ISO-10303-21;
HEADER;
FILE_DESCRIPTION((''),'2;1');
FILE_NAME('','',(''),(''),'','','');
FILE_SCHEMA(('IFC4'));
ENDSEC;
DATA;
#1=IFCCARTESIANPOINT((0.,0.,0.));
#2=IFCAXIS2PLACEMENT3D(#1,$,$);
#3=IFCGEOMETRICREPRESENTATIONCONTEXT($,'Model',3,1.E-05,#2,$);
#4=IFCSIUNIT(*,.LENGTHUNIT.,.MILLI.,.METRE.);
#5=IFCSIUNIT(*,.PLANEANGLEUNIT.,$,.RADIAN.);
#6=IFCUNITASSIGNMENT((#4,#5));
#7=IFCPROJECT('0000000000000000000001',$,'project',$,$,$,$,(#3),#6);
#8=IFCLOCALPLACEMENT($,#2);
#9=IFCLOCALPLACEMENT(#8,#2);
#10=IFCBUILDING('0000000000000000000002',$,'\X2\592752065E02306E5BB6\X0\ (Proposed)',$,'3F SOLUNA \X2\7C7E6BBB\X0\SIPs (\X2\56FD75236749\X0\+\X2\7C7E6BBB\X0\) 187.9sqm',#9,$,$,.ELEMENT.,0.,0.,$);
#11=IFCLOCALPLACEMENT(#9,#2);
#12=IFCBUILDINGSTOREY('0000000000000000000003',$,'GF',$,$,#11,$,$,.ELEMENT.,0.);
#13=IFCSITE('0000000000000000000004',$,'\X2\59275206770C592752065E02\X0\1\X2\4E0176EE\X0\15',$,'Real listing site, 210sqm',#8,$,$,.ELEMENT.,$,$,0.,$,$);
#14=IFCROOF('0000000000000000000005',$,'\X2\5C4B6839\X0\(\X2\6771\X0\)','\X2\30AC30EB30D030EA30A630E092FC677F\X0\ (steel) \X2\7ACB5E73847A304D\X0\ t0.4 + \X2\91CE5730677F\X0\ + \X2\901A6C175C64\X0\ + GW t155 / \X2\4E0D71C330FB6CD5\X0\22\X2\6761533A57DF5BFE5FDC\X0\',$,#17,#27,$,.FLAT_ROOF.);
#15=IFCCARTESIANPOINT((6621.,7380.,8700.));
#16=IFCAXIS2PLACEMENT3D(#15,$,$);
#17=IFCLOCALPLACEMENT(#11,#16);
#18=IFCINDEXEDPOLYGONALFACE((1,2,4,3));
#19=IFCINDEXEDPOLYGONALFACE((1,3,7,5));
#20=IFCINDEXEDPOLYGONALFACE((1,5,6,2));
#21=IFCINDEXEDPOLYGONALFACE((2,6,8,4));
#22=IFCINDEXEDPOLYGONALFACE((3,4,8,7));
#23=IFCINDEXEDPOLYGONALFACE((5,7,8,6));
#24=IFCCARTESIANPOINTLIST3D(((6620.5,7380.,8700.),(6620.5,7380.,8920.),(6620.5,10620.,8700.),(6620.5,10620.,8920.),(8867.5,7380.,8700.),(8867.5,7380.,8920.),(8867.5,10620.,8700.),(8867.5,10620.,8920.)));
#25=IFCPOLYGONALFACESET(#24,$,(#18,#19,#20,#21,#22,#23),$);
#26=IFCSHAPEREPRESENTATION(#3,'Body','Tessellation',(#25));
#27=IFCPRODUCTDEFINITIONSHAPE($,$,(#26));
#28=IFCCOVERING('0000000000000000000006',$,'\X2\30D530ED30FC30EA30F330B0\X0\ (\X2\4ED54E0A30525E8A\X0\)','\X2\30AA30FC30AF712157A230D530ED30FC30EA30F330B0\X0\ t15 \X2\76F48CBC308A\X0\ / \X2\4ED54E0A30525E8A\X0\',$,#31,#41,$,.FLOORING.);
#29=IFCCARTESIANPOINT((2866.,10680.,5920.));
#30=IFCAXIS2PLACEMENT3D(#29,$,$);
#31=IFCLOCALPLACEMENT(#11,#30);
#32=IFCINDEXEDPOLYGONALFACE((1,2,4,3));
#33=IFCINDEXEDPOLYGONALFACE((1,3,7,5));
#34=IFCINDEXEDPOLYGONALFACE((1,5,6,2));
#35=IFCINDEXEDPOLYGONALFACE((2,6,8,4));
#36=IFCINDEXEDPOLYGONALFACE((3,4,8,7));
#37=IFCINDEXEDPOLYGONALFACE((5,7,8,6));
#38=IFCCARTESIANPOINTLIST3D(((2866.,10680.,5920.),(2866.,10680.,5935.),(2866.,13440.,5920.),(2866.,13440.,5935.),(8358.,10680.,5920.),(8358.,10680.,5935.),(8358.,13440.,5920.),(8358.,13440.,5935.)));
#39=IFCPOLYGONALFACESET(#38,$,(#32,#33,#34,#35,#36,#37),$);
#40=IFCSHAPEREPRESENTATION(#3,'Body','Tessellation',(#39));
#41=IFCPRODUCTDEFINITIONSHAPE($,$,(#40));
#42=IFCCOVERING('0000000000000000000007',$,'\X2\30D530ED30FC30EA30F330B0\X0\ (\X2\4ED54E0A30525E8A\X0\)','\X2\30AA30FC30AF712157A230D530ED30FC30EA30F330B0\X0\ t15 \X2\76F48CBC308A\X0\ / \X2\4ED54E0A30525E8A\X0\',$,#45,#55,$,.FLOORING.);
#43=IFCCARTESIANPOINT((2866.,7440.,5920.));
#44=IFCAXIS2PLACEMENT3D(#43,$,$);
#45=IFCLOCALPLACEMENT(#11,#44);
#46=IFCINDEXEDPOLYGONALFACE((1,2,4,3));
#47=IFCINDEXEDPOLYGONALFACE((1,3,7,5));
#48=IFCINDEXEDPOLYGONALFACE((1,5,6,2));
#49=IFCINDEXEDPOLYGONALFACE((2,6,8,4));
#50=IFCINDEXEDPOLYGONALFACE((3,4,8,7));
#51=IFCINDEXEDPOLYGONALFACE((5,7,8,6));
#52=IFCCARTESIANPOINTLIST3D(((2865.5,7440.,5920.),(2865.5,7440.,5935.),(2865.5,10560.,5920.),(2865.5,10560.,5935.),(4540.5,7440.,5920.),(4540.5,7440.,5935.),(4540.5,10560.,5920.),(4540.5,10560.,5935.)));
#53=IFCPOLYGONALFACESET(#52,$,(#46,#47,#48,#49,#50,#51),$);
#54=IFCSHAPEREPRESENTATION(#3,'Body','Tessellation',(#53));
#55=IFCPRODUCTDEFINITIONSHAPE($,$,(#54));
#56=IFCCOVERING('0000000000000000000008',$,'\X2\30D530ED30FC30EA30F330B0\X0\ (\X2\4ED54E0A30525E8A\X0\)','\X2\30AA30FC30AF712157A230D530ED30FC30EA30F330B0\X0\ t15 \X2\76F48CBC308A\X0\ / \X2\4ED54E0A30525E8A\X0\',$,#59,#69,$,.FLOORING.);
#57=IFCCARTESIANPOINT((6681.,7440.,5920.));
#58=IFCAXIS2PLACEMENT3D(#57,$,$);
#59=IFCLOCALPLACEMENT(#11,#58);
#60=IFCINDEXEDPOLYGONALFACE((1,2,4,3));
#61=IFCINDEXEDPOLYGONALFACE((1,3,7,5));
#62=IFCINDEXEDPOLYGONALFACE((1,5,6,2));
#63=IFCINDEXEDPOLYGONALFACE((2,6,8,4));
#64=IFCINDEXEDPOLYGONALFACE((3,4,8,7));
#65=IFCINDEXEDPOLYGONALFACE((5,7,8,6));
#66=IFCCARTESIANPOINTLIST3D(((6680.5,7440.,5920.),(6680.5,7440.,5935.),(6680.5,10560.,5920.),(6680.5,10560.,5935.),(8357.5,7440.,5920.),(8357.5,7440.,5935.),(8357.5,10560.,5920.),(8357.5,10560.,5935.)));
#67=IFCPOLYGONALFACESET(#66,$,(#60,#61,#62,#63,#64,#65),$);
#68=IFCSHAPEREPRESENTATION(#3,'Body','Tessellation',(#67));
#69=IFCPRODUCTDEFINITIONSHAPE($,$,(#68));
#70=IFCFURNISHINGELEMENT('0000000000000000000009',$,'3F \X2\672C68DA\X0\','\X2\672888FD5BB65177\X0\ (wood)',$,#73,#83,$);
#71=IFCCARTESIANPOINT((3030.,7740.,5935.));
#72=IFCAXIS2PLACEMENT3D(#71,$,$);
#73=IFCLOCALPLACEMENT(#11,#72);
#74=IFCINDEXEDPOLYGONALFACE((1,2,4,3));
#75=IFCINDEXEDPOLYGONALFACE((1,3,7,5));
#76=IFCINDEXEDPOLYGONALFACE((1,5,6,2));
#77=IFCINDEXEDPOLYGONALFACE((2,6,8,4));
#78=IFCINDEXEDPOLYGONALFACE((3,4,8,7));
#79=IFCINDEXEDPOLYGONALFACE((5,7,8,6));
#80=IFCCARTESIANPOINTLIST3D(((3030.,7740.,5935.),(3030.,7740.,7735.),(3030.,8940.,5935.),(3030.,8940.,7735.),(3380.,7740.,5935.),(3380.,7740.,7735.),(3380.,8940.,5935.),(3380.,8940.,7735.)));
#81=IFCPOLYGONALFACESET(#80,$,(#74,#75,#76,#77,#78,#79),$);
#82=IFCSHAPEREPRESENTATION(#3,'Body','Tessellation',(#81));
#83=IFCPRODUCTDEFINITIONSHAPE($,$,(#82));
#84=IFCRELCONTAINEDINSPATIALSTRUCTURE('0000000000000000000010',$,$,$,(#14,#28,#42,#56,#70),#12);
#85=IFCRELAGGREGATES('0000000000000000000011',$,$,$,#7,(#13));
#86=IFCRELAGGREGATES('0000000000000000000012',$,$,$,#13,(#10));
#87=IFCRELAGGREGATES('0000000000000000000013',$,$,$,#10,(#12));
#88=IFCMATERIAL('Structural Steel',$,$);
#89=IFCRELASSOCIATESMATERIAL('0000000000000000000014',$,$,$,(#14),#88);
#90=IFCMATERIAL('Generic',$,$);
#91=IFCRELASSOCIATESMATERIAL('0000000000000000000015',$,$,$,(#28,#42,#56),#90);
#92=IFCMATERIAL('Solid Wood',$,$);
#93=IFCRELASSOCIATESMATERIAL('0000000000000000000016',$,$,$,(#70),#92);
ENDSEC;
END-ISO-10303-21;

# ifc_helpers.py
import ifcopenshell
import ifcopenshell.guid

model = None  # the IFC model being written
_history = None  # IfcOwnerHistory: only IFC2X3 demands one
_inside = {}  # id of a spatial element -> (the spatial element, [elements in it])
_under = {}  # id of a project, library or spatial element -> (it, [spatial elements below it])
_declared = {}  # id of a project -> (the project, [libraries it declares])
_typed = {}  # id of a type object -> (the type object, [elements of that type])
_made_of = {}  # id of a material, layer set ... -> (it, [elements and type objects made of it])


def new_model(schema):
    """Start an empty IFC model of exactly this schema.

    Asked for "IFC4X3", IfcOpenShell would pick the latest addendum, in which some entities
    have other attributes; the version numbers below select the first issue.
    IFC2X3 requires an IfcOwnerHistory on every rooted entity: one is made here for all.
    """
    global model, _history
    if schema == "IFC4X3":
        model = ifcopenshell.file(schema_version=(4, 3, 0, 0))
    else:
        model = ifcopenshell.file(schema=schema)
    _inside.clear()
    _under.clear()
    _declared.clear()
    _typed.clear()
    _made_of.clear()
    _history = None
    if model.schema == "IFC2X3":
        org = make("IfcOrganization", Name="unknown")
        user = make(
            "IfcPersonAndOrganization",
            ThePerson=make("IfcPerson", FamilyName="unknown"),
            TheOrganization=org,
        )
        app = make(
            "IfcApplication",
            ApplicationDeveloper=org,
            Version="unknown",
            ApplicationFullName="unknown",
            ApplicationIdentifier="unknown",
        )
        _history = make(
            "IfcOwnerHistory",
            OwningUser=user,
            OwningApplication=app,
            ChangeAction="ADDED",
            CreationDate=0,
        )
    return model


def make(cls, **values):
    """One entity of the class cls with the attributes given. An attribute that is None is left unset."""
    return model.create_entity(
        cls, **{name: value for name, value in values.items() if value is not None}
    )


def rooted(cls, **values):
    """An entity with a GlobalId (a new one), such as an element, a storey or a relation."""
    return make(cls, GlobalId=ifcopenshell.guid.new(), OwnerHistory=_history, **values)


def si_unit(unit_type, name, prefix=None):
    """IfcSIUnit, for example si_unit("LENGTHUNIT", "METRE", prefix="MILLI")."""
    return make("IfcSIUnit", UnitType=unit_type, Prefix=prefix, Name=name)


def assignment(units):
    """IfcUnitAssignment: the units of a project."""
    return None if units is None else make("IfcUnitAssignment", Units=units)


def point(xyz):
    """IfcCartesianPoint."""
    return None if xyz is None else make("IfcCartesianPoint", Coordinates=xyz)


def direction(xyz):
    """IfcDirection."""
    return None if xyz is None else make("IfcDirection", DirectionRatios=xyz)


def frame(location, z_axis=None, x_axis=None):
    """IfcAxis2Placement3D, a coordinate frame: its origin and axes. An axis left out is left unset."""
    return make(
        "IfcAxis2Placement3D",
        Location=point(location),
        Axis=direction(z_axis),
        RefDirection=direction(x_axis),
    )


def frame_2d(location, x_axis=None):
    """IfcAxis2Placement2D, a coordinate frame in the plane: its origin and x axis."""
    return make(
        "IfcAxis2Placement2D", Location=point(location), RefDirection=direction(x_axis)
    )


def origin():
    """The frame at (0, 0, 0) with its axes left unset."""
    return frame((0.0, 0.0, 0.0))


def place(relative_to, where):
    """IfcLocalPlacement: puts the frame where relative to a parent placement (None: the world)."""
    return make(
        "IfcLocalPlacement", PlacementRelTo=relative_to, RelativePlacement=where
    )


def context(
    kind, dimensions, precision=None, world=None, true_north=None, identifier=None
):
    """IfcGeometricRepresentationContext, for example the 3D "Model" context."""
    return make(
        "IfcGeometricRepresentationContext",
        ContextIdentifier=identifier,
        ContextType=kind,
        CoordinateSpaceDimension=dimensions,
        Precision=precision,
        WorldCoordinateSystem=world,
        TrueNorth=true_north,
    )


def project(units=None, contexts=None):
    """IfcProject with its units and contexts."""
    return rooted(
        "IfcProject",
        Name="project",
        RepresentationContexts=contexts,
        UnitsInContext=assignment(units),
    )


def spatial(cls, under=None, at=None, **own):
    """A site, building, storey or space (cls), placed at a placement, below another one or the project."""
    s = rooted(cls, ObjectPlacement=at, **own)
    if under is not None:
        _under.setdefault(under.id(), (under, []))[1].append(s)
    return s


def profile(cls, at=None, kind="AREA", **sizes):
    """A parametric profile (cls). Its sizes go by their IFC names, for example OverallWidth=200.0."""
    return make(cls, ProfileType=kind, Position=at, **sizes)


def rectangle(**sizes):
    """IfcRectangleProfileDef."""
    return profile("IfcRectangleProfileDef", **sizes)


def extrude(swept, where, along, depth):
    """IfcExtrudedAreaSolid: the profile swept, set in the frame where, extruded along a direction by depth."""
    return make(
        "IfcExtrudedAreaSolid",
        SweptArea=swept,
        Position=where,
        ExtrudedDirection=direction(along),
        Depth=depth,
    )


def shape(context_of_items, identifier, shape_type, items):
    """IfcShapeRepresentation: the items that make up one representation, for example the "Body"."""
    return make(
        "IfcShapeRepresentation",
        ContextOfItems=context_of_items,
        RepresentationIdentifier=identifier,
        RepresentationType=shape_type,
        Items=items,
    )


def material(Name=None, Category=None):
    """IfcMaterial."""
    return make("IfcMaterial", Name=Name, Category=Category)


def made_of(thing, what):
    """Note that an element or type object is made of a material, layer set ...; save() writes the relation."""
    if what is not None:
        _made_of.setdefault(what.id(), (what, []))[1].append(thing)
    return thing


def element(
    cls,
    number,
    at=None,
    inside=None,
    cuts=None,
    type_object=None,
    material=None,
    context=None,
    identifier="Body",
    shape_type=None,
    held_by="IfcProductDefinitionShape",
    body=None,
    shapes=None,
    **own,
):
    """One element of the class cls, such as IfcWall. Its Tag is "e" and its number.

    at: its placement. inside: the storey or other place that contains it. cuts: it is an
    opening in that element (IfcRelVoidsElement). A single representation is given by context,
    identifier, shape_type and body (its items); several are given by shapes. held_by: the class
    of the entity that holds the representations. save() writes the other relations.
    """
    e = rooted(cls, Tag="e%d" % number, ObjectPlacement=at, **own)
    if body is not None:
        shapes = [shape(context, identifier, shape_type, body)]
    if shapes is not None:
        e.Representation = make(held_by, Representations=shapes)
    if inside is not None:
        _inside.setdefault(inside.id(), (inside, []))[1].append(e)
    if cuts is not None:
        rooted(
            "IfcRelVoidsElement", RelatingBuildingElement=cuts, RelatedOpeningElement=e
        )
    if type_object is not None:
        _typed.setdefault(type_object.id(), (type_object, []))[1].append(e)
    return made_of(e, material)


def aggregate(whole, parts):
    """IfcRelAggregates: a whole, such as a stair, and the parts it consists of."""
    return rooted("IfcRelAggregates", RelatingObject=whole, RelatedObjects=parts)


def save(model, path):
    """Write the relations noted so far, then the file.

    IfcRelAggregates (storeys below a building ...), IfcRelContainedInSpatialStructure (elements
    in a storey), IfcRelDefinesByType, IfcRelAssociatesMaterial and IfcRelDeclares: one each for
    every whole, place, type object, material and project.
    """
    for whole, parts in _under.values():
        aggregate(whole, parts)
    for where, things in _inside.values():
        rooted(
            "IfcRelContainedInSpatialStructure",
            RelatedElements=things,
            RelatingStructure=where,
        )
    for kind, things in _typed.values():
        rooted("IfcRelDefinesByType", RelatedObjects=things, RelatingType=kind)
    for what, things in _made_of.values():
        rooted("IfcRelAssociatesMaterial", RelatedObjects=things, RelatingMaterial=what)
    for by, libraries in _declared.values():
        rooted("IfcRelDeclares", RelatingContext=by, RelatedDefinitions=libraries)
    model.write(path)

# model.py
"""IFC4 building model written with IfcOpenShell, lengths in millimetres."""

from ifc_helpers import new_model, si_unit, frame, frame_2d, origin, place, context, project, spatial, rectangle, extrude, material, element, save


model = new_model("IFC4")

# Units and contexts
model_context = context("Model", 3, precision=1e-05, world=origin())
ifc_project = project(units=[si_unit("LENGTHUNIT", "METRE", prefix="MILLI"), si_unit("PLANEANGLEUNIT", "RADIAN")], contexts=[model_context])

# Site, building, storey
site_placement = place(None, origin())
site = spatial("IfcSite", under=ifc_project, at=site_placement, Name="大分県大分市1丁目15", ObjectType="Real listing site, 210sqm", CompositionType="ELEMENT", RefElevation=0.0)
building_placement = place(site_placement, origin())
building = spatial("IfcBuilding", under=site, at=building_placement, Name="大分市の家 (Proposed)", ObjectType="3F SOLUNA 籾殻SIPs (国産杉+籾殻) 187.9sqm", CompositionType="ELEMENT", ElevationOfRefHeight=0.0, ElevationOfTerrain=0.0)
storey_placement = place(building_placement, origin())
storey = spatial("IfcBuildingStorey", under=building, at=storey_placement, Name="GF", CompositionType="ELEMENT", Elevation=0.0)

# Shared definitions
ifc_material_1 = material(Name="Solid Wood")

# Shared definitions
ifc_material_2 = material(Name="Generic")

# Roof
ifc_material_3 = material(Name="Structural Steel")
roof_1_placement = place(storey_placement, frame((6621.0, 7380.0, 8700.0)))
element("IfcRoof", 1, at=roof_1_placement, inside=storey, material=ifc_material_3, Name="屋根(東)", Description="ガルバリウム鋼板 (steel) 立平葺き t0.4 + 野地板 + 通気層 + GW t155 / 不燃・法22条区域対応", PredefinedType="FLAT_ROOF", context=model_context, shape_type="SweptSolid", body=[
    extrude(rectangle(XDim=2247.0, YDim=3240.0, at=frame_2d((1123.0, 1620.0))), frame((6621.0, 7380.0, 8700.0)), (0.0, 0.0, 1.0), 220.0),
])

# Coverings
covering_1_placement = place(storey_placement, frame((2866.0, 10680.0, 5920.0)))
element("IfcCovering", 2, at=covering_1_placement, inside=storey, material=ifc_material_2, Name="フローリング (仕上げ床)", Description="オーク無垢フローリング t15 直貼り / 仕上げ床", PredefinedType="FLOORING", context=model_context, shape_type="SweptSolid", body=[
    extrude(rectangle(XDim=5492.0, YDim=2760.0, at=frame_2d((2746.0, 1380.0))), frame((2866.0, 10680.0, 5920.0)), (0.0, 0.0, 1.0), 15.0),
])
covering_2_placement = place(storey_placement, frame((2866.0, 7440.0, 5920.0)))
element("IfcCovering", 3, at=covering_2_placement, inside=storey, material=ifc_material_2, Name="フローリング (仕上げ床)", Description="オーク無垢フローリング t15 直貼り / 仕上げ床", PredefinedType="FLOORING", context=model_context, shape_type="SweptSolid", body=[
    extrude(rectangle(XDim=1675.0, YDim=3120.0, at=frame_2d((837.0, 1560.0))), frame((2866.0, 7440.0, 5920.0)), (0.0, 0.0, 1.0), 15.0),
])
covering_3_placement = place(storey_placement, frame((6681.0, 7440.0, 5920.0)))
element("IfcCovering", 4, at=covering_3_placement, inside=storey, material=ifc_material_2, Name="フローリング (仕上げ床)", Description="オーク無垢フローリング t15 直貼り / 仕上げ床", PredefinedType="FLOORING", context=model_context, shape_type="SweptSolid", body=[
    extrude(rectangle(XDim=1677.0, YDim=3120.0, at=frame_2d((838.0, 1560.0))), frame((6681.0, 7440.0, 5920.0)), (0.0, 0.0, 1.0), 15.0),
])

# Furnishing element
furnishing_placement = place(storey_placement, frame((3030.0, 7740.0, 5935.0)))
element("IfcFurnishingElement", 5, at=furnishing_placement, inside=storey, material=ifc_material_1, Name="3F 本棚", Description="木製家具 (wood)", context=model_context, shape_type="SweptSolid", body=[
    extrude(rectangle(XDim=350.0, YDim=1200.0, at=frame_2d((175.0, 600.0))), frame((3030.0, 7740.0, 5935.0)), (0.0, 0.0, 1.0), 1800.0),
])

save(model, "model.ifc")
